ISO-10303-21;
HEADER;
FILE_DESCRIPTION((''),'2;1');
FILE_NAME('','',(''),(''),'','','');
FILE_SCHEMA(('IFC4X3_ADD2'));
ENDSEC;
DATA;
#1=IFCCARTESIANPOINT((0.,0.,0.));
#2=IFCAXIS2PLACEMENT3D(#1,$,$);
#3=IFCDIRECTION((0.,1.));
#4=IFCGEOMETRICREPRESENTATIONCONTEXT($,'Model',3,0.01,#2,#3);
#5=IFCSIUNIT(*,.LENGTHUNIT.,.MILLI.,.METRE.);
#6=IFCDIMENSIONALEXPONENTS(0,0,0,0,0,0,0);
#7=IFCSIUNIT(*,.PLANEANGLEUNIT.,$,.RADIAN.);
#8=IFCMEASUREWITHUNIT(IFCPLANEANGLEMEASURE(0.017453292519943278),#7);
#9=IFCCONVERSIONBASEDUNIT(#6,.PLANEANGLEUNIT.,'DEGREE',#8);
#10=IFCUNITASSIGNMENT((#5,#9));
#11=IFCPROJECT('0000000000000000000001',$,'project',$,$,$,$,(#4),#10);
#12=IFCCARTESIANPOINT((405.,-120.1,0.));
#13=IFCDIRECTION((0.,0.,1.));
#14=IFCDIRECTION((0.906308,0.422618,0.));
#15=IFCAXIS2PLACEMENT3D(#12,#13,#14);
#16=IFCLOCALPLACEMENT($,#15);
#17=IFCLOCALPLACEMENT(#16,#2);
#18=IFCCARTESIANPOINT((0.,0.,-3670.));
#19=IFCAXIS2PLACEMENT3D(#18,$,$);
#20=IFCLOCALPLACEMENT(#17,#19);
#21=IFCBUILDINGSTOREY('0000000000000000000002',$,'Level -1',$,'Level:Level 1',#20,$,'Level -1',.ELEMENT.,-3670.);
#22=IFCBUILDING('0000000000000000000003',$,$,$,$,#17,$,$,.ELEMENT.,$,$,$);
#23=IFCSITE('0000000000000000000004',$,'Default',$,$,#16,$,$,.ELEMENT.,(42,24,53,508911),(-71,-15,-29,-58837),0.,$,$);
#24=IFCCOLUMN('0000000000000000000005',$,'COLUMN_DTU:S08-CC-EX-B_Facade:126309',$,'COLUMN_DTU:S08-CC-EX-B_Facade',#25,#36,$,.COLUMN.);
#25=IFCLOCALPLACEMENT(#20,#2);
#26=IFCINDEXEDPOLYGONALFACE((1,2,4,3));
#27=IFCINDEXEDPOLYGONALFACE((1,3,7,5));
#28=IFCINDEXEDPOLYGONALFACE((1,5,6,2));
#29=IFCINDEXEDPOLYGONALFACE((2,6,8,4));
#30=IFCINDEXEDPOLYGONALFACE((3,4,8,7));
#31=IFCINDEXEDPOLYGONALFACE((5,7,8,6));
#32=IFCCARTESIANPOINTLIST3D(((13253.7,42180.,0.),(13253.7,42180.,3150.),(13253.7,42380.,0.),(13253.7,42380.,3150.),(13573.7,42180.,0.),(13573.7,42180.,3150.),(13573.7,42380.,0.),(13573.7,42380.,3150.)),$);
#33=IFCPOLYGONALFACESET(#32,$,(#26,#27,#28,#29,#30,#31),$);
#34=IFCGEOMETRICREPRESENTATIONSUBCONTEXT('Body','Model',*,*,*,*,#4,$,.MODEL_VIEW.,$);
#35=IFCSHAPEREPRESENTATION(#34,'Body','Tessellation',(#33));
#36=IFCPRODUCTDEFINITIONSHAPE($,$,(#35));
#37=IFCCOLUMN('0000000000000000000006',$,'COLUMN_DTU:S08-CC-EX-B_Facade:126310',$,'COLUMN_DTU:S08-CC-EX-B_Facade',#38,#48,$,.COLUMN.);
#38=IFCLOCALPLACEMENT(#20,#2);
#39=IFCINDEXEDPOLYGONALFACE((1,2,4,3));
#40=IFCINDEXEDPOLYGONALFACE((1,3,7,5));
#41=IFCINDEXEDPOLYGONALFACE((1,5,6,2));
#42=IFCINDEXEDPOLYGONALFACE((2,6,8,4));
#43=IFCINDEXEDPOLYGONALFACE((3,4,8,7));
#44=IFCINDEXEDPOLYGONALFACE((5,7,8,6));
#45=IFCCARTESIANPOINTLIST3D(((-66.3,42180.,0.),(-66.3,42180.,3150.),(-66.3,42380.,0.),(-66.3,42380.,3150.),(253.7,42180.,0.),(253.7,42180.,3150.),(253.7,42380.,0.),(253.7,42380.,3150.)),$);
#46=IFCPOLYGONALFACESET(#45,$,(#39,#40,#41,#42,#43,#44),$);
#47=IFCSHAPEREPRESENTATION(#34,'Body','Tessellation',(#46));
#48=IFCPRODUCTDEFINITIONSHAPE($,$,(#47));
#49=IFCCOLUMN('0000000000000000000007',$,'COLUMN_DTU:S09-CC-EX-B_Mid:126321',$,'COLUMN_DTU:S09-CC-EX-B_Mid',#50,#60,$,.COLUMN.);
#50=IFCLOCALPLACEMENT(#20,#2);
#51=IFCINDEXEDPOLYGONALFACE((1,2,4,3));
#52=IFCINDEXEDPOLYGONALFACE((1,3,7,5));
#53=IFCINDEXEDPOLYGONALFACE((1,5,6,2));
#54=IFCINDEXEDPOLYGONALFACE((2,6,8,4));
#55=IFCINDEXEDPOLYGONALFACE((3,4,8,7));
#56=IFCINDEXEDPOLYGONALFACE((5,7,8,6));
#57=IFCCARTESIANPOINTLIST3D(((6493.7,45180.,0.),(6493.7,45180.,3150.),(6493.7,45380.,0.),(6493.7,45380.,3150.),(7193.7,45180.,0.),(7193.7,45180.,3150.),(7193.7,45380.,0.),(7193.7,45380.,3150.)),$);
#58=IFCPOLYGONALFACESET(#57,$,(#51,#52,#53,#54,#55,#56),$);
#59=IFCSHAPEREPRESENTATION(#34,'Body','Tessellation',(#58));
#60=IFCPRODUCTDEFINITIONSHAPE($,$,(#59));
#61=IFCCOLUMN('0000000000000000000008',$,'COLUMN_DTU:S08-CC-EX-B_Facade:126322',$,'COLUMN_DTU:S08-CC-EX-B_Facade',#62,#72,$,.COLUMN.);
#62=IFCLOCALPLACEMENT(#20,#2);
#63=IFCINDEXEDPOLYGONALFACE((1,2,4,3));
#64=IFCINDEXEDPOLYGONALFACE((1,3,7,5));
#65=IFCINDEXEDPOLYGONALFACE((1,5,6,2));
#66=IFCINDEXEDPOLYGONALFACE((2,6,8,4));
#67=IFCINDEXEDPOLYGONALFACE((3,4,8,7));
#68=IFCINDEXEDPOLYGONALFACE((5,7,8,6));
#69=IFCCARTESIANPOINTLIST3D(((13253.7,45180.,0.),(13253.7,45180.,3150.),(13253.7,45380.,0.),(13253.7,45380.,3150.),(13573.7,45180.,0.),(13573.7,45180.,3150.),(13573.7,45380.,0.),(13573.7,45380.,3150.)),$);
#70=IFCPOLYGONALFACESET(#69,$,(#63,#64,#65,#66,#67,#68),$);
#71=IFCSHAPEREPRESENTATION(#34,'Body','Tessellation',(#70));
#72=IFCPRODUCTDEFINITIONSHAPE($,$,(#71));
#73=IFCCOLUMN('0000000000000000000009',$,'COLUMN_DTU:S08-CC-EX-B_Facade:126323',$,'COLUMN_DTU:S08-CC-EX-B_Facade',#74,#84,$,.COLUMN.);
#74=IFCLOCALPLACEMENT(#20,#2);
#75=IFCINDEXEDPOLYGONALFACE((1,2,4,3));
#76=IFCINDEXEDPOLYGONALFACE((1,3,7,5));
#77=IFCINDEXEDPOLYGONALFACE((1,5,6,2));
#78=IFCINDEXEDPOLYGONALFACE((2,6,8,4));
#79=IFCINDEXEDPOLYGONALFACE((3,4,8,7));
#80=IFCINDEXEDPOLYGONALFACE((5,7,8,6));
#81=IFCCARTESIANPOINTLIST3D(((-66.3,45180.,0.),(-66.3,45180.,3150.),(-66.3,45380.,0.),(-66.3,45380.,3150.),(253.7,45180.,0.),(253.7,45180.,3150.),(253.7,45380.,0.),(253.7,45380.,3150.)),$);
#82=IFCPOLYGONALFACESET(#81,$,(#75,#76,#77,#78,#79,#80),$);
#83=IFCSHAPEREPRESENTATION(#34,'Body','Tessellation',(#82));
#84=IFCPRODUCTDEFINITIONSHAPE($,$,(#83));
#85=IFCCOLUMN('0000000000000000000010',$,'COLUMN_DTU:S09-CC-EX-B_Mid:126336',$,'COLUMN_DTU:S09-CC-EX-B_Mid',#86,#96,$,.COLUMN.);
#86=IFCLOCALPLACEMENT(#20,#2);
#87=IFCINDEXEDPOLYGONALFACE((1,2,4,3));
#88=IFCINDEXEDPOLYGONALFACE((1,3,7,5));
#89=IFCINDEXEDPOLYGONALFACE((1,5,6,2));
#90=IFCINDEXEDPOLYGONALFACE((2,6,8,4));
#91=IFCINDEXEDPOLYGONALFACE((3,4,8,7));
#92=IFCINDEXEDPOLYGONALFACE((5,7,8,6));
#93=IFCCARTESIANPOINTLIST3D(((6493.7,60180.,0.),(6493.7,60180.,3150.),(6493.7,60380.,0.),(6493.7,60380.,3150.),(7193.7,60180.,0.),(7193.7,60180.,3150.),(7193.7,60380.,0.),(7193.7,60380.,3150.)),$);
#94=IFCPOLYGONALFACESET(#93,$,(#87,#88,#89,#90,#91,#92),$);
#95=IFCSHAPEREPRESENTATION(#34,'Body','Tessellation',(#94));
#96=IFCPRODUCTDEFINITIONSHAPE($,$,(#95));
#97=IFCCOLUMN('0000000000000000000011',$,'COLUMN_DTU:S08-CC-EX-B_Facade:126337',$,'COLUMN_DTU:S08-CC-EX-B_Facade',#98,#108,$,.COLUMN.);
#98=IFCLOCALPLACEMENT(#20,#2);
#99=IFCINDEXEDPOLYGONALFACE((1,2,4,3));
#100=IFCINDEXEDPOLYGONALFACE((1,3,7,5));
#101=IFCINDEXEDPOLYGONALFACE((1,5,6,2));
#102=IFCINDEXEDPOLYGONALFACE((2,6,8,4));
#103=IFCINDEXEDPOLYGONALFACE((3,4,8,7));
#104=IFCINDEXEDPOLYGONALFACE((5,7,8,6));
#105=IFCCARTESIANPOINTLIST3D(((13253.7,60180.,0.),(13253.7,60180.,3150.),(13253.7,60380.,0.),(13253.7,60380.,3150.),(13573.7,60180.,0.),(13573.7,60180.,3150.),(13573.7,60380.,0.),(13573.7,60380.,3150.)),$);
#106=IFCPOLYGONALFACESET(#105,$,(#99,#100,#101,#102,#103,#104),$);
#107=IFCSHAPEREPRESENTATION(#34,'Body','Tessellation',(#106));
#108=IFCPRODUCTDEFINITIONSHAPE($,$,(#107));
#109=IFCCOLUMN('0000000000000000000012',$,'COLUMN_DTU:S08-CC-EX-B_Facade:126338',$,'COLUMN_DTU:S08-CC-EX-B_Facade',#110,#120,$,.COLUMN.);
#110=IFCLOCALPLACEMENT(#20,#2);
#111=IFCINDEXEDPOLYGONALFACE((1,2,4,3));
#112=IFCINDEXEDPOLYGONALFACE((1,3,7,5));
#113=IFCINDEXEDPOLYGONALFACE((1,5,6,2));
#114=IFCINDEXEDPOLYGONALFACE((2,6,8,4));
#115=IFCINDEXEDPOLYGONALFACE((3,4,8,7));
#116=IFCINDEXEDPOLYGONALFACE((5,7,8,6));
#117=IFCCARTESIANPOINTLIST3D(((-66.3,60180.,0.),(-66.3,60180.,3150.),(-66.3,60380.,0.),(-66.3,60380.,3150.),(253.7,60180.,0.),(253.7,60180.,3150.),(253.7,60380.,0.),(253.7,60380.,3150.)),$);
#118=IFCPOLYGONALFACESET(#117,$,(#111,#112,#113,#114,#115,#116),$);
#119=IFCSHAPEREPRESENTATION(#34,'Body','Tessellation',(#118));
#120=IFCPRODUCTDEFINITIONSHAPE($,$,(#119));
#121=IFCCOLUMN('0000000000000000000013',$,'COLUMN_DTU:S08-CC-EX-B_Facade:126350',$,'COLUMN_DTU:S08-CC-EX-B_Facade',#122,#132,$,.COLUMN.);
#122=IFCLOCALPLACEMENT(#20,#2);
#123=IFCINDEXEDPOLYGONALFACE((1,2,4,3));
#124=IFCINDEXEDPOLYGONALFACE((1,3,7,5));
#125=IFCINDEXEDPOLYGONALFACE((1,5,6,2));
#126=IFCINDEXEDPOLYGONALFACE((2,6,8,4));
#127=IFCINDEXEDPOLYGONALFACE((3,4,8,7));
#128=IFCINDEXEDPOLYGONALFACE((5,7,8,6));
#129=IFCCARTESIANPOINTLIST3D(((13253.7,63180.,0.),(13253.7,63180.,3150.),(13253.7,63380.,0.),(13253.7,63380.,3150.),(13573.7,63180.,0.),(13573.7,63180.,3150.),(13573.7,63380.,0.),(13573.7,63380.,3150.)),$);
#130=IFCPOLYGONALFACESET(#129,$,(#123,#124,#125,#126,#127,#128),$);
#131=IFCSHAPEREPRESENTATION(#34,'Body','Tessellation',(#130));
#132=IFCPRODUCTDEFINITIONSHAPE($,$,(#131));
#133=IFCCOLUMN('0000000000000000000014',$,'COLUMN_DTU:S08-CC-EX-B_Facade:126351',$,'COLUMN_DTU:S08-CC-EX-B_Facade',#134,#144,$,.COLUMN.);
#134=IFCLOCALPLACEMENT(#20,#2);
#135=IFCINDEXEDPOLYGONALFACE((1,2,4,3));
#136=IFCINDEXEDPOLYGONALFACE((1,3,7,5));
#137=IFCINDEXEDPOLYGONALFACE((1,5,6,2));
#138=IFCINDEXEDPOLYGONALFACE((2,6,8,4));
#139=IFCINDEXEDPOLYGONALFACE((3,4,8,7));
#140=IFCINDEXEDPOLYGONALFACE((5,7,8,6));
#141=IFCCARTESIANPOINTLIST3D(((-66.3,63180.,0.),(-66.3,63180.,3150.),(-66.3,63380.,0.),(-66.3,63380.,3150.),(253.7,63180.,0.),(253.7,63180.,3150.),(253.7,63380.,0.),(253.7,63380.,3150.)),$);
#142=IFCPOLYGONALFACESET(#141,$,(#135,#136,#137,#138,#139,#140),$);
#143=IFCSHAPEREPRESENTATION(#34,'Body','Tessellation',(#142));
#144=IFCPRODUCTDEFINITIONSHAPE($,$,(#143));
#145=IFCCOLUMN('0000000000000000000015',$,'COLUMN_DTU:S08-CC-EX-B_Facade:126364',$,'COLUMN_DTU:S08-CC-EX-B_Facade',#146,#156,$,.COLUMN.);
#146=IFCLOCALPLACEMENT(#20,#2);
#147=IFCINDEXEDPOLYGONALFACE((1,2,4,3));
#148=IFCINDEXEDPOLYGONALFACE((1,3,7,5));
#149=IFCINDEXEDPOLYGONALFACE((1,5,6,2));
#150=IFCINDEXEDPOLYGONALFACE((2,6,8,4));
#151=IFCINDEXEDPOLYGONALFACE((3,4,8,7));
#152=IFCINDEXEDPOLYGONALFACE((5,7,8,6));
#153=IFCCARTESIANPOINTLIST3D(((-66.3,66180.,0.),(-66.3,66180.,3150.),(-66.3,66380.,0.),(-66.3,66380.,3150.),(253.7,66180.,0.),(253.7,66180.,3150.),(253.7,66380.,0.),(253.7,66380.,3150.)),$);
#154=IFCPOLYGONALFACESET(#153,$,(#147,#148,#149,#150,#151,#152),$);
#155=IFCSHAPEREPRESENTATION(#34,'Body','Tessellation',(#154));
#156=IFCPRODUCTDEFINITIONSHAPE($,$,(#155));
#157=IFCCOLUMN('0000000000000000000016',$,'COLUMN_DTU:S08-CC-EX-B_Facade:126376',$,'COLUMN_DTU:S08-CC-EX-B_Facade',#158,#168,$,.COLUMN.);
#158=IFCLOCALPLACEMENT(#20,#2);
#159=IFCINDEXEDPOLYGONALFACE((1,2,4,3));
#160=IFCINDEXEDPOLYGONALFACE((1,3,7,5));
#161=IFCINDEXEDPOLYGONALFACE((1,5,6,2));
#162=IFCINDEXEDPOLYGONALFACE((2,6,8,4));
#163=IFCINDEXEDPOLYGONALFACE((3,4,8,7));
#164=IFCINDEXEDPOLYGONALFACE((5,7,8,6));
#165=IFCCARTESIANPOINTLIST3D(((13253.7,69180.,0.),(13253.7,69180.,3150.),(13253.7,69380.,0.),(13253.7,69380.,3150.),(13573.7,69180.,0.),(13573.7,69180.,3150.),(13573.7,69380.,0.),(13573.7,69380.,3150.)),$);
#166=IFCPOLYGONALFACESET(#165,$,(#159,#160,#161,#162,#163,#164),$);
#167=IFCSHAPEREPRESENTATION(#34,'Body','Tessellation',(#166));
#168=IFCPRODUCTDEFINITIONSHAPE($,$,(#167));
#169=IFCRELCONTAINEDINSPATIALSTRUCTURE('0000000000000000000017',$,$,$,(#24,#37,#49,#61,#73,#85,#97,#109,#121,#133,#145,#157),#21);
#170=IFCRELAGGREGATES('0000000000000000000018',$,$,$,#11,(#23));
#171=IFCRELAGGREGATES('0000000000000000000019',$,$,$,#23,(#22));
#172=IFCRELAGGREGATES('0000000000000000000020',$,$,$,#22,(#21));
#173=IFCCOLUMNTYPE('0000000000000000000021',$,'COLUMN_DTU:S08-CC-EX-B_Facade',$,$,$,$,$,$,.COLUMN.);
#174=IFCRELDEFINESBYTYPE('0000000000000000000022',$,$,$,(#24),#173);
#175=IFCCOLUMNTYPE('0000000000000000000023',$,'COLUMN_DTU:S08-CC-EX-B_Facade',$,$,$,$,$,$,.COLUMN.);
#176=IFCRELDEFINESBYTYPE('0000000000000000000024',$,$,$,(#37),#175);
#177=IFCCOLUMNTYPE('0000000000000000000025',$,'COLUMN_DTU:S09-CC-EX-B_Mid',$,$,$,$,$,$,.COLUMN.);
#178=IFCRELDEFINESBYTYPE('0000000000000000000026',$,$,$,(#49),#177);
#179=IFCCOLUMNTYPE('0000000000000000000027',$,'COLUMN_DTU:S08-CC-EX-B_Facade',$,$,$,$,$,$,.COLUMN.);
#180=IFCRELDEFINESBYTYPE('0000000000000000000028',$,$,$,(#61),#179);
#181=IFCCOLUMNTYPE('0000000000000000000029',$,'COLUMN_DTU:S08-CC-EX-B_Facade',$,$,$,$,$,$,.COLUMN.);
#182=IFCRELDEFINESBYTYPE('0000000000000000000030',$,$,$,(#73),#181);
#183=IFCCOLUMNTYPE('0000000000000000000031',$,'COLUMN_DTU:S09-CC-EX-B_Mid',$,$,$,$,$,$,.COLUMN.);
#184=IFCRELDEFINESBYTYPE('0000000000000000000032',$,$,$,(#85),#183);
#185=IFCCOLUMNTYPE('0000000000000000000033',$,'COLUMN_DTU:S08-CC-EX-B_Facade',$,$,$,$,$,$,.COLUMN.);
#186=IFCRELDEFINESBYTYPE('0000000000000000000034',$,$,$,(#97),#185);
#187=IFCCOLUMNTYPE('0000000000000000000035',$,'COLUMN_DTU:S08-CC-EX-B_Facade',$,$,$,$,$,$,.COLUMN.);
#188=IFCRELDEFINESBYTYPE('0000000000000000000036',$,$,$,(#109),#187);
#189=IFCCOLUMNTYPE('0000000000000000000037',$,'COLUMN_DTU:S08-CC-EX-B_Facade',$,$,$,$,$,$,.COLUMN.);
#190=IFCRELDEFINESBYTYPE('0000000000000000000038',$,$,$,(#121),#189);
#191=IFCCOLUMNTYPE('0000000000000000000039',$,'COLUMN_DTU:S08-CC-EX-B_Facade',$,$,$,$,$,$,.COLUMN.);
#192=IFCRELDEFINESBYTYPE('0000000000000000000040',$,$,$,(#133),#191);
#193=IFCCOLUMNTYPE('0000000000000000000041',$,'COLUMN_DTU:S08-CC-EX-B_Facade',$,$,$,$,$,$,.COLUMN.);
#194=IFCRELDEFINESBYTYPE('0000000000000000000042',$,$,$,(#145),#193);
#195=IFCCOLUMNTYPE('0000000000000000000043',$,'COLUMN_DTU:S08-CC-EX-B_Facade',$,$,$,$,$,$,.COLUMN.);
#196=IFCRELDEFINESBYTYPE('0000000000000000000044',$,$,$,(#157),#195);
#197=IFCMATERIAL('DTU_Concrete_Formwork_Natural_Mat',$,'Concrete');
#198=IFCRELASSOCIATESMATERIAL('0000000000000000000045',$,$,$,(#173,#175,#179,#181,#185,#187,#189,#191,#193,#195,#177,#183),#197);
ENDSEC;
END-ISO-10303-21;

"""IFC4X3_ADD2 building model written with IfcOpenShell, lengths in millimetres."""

from ifc_helpers import new_model, entity, si_unit, converted_unit, direction, frame, frame_2d, origin, origin_2d_with_axis, place, context, subcontext, project, spatial, rectangle, extrude, source, transform, mapped, material, material_profile, profile_set, type_object, type_shapes, element, save


model = new_model("IFC4X3_ADD2")

# Units and contexts
model_context = context("Model", 3, precision=0.01, world=origin(), true_north=direction((0.0, 1.0)))
body_context = subcontext(model_context, "Body", "Model", "MODEL_VIEW")
ifc_project = project(units=[si_unit("LENGTHUNIT", "METRE", prefix="MILLI"), converted_unit("PLANEANGLEUNIT", "DEGREE", entity("IfcPlaneAngleMeasure", 0.017453292519943278), si_unit("PLANEANGLEUNIT", "RADIAN"), dimensions=[0, 0, 0, 0, 0, 0, 0])], contexts=[model_context])

# Site, building, storey
site_placement = place(None, frame((405.0, -120.1, 0.0), z_axis=(0.0, 0.0, 1.0), x_axis=(0.906308, 0.422618, 0.0)))
site = spatial("IfcSite", under=ifc_project, at=site_placement, Name="Default", CompositionType="ELEMENT", RefLatitude=(42, 24, 53, 508911), RefLongitude=(-71, -15, -29, -58837), RefElevation=0.0)
building_placement = place(site_placement, origin())
building = spatial("IfcBuilding", under=site, at=building_placement, CompositionType="ELEMENT")
storey_placement = place(building_placement, frame((0.0, 0.0, -3670.0)))
storey = spatial("IfcBuildingStorey", under=building, at=storey_placement, Name="Level -1", ObjectType="Level:Level 1", LongName="Level -1", CompositionType="ELEMENT", Elevation=-3670.0)

# Columns
ifc_material = material(Name="DTU_Concrete_Formwork_Natural_Mat", Category="Concrete")
ifc_material_profile_1 = material_profile(ifc_material, rectangle(XDim=200.0, YDim=320.0, at=origin_2d_with_axis()), Name="S08-CC-EX-B_Facade")
ifc_profile_set_1 = profile_set([ifc_material_profile_1], Name="S08-CC-EX-B_Facade")
ifc_material_profile_2 = material_profile(ifc_material, rectangle(XDim=200.0, YDim=700.0, at=frame_2d((0.0, 0.0), x_axis=(1.0, 0.0))), Name="S09-CC-EX-B_Mid")
ifc_profile_set_2 = profile_set([ifc_material_profile_2], Name="S09-CC-EX-B_Mid")
column_type_1 = type_object("IfcColumnType", Name="COLUMN_DTU:S08-CC-EX-B_Facade", PredefinedType="COLUMN", material=ifc_profile_set_1)
shared_shape_1 = source(origin(), body_context, "Body", "SweptSolid", [
    extrude(rectangle(XDim=200.0, YDim=320.0, at=frame_2d((0.0, 0.0), x_axis=(1.0, 0.0))), frame((13413.7, 42280.0, -3670.0), z_axis=(0.0, 0.0, 1.0), x_axis=(0.0, 1.0, 0.0)), (0.0, 0.0, 1.0), 3150.0),
])
type_shapes(column_type_1, [shared_shape_1])
column_1_placement = place(storey_placement, frame((0.0, 0.0, 3670.0)))
element("IfcColumn", 1, at=column_1_placement, inside=storey, type_object=column_type_1, Name="COLUMN_DTU:S08-CC-EX-B_Facade:126309", ObjectType="COLUMN_DTU:S08-CC-EX-B_Facade", PredefinedType="COLUMN", context=body_context, shape_type="MappedRepresentation", body=[
    mapped(shared_shape_1, transform((0.0, 0.0, 0.0), scale=1.0)),
])
column_type_2 = type_object("IfcColumnType", Name="COLUMN_DTU:S08-CC-EX-B_Facade", PredefinedType="COLUMN", material=ifc_profile_set_1)
shared_shape_2 = source(origin(), body_context, "Body", "SweptSolid", [
    extrude(rectangle(XDim=200.0, YDim=320.0, at=frame_2d((0.0, 0.0), x_axis=(1.0, 0.0))), frame((93.7, 42280.0, -3670.0), z_axis=(0.0, 0.0, 1.0), x_axis=(0.0, 1.0, 0.0)), (0.0, 0.0, 1.0), 3150.0),
])
type_shapes(column_type_2, [shared_shape_2])
column_2_placement = place(storey_placement, frame((0.0, 0.0, 3670.0)))
element("IfcColumn", 2, at=column_2_placement, inside=storey, type_object=column_type_2, Name="COLUMN_DTU:S08-CC-EX-B_Facade:126310", ObjectType="COLUMN_DTU:S08-CC-EX-B_Facade", PredefinedType="COLUMN", context=body_context, shape_type="MappedRepresentation", body=[
    mapped(shared_shape_2, transform((0.0, 0.0, 0.0), scale=1.0)),
])
column_type_3 = type_object("IfcColumnType", Name="COLUMN_DTU:S09-CC-EX-B_Mid", PredefinedType="COLUMN", material=ifc_profile_set_2)
shared_shape_3 = source(origin(), body_context, "Body", "SweptSolid", [
    extrude(rectangle(XDim=200.0, YDim=700.0, at=frame_2d((0.0, 0.0), x_axis=(1.0, 0.0))), frame((6843.7, 45280.0, -3670.0), z_axis=(0.0, 0.0, 1.0), x_axis=(0.0, 1.0, 0.0)), (0.0, 0.0, 1.0), 3150.0),
])
type_shapes(column_type_3, [shared_shape_3])
column_3_placement = place(storey_placement, frame((0.0, 0.0, 3670.0)))
element("IfcColumn", 3, at=column_3_placement, inside=storey, type_object=column_type_3, Name="COLUMN_DTU:S09-CC-EX-B_Mid:126321", ObjectType="COLUMN_DTU:S09-CC-EX-B_Mid", PredefinedType="COLUMN", context=body_context, shape_type="MappedRepresentation", body=[
    mapped(shared_shape_3, transform((0.0, 0.0, 0.0), scale=1.0)),
])
column_type_4 = type_object("IfcColumnType", Name="COLUMN_DTU:S08-CC-EX-B_Facade", PredefinedType="COLUMN", material=ifc_profile_set_1)
shared_shape_4 = source(origin(), body_context, "Body", "SweptSolid", [
    extrude(rectangle(XDim=200.0, YDim=320.0, at=frame_2d((0.0, 0.0), x_axis=(1.0, 0.0))), frame((13413.7, 45280.0, -3670.0), z_axis=(0.0, 0.0, 1.0), x_axis=(0.0, 1.0, 0.0)), (0.0, 0.0, 1.0), 3150.0),
])
type_shapes(column_type_4, [shared_shape_4])
column_4_placement = place(storey_placement, frame((0.0, 0.0, 3670.0)))
element("IfcColumn", 4, at=column_4_placement, inside=storey, type_object=column_type_4, Name="COLUMN_DTU:S08-CC-EX-B_Facade:126322", ObjectType="COLUMN_DTU:S08-CC-EX-B_Facade", PredefinedType="COLUMN", context=body_context, shape_type="MappedRepresentation", body=[
    mapped(shared_shape_4, transform((0.0, 0.0, 0.0), scale=1.0)),
])
column_type_5 = type_object("IfcColumnType", Name="COLUMN_DTU:S08-CC-EX-B_Facade", PredefinedType="COLUMN", material=ifc_profile_set_1)
shared_shape_5 = source(origin(), body_context, "Body", "SweptSolid", [
    extrude(rectangle(XDim=200.0, YDim=320.0, at=frame_2d((0.0, 0.0), x_axis=(1.0, 0.0))), frame((93.7, 45280.0, -3670.0), z_axis=(0.0, 0.0, 1.0), x_axis=(0.0, 1.0, 0.0)), (0.0, 0.0, 1.0), 3150.0),
])
type_shapes(column_type_5, [shared_shape_5])
column_5_placement = place(storey_placement, frame((0.0, 0.0, 3670.0)))
element("IfcColumn", 5, at=column_5_placement, inside=storey, type_object=column_type_5, Name="COLUMN_DTU:S08-CC-EX-B_Facade:126323", ObjectType="COLUMN_DTU:S08-CC-EX-B_Facade", PredefinedType="COLUMN", context=body_context, shape_type="MappedRepresentation", body=[
    mapped(shared_shape_5, transform((0.0, 0.0, 0.0), scale=1.0)),
])
column_type_6 = type_object("IfcColumnType", Name="COLUMN_DTU:S09-CC-EX-B_Mid", PredefinedType="COLUMN", material=ifc_profile_set_2)
shared_shape_6 = source(origin(), body_context, "Body", "SweptSolid", [
    extrude(rectangle(XDim=200.0, YDim=700.0, at=frame_2d((0.0, 0.0), x_axis=(1.0, 0.0))), frame((6843.7, 60280.0, -3670.0), z_axis=(0.0, 0.0, 1.0), x_axis=(0.0, -1.0, 0.0)), (0.0, 0.0, 1.0), 3150.0),
])
type_shapes(column_type_6, [shared_shape_6])
column_6_placement = place(storey_placement, frame((0.0, 0.0, 3670.0)))
element("IfcColumn", 6, at=column_6_placement, inside=storey, type_object=column_type_6, Name="COLUMN_DTU:S09-CC-EX-B_Mid:126336", ObjectType="COLUMN_DTU:S09-CC-EX-B_Mid", PredefinedType="COLUMN", context=body_context, shape_type="MappedRepresentation", body=[
    mapped(shared_shape_6, transform((0.0, 0.0, 0.0), scale=1.0)),
])
column_type_7 = type_object("IfcColumnType", Name="COLUMN_DTU:S08-CC-EX-B_Facade", PredefinedType="COLUMN", material=ifc_profile_set_1)
shared_shape_7 = source(origin(), body_context, "Body", "SweptSolid", [
    extrude(rectangle(XDim=200.0, YDim=320.0, at=frame_2d((0.0, 0.0), x_axis=(1.0, 0.0))), frame((13413.7, 60280.0, -3670.0), z_axis=(0.0, 0.0, 1.0), x_axis=(0.0, 1.0, 0.0)), (0.0, 0.0, 1.0), 3150.0),
])
type_shapes(column_type_7, [shared_shape_7])
column_7_placement = place(storey_placement, frame((0.0, 0.0, 3670.0)))
element("IfcColumn", 7, at=column_7_placement, inside=storey, type_object=column_type_7, Name="COLUMN_DTU:S08-CC-EX-B_Facade:126337", ObjectType="COLUMN_DTU:S08-CC-EX-B_Facade", PredefinedType="COLUMN", context=body_context, shape_type="MappedRepresentation", body=[
    mapped(shared_shape_7, transform((0.0, 0.0, 0.0), scale=1.0)),
])
column_type_8 = type_object("IfcColumnType", Name="COLUMN_DTU:S08-CC-EX-B_Facade", PredefinedType="COLUMN", material=ifc_profile_set_1)
shared_shape_8 = source(origin(), body_context, "Body", "SweptSolid", [
    extrude(rectangle(XDim=200.0, YDim=320.0, at=frame_2d((0.0, 0.0), x_axis=(1.0, 0.0))), frame((93.7, 60280.0, -3670.0), z_axis=(0.0, 0.0, 1.0), x_axis=(0.0, -1.0, 0.0)), (0.0, 0.0, 1.0), 3150.0),
])
type_shapes(column_type_8, [shared_shape_8])
column_8_placement = place(storey_placement, frame((0.0, 0.0, 3670.0)))
element("IfcColumn", 8, at=column_8_placement, inside=storey, type_object=column_type_8, Name="COLUMN_DTU:S08-CC-EX-B_Facade:126338", ObjectType="COLUMN_DTU:S08-CC-EX-B_Facade", PredefinedType="COLUMN", context=body_context, shape_type="MappedRepresentation", body=[
    mapped(shared_shape_8, transform((0.0, 0.0, 0.0), scale=1.0)),
])
column_type_9 = type_object("IfcColumnType", Name="COLUMN_DTU:S08-CC-EX-B_Facade", PredefinedType="COLUMN", material=ifc_profile_set_1)
shared_shape_9 = source(origin(), body_context, "Body", "SweptSolid", [
    extrude(rectangle(XDim=200.0, YDim=320.0, at=frame_2d((0.0, 0.0), x_axis=(1.0, 0.0))), frame((13413.7, 63280.0, -3670.0), z_axis=(0.0, 0.0, 1.0), x_axis=(0.0, 1.0, 0.0)), (0.0, 0.0, 1.0), 3150.0),
])
type_shapes(column_type_9, [shared_shape_9])
column_9_placement = place(storey_placement, frame((0.0, 0.0, 3670.0)))
element("IfcColumn", 9, at=column_9_placement, inside=storey, type_object=column_type_9, Name="COLUMN_DTU:S08-CC-EX-B_Facade:126350", ObjectType="COLUMN_DTU:S08-CC-EX-B_Facade", PredefinedType="COLUMN", context=body_context, shape_type="MappedRepresentation", body=[
    mapped(shared_shape_9, transform((0.0, 0.0, 0.0), scale=1.0)),
])
column_type_10 = type_object("IfcColumnType", Name="COLUMN_DTU:S08-CC-EX-B_Facade", PredefinedType="COLUMN", material=ifc_profile_set_1)
shared_shape_10 = source(origin(), body_context, "Body", "SweptSolid", [
    extrude(rectangle(XDim=200.0, YDim=320.0, at=origin_2d_with_axis()), frame((93.7, 63280.0, -3670.0), z_axis=(0.0, 0.0, 1.0), x_axis=(0.0, -1.0, 0.0)), (0.0, 0.0, 1.0), 3150.0),
])
type_shapes(column_type_10, [shared_shape_10])
column_10_placement = place(storey_placement, frame((0.0, 0.0, 3670.0)))
element("IfcColumn", 10, at=column_10_placement, inside=storey, type_object=column_type_10, Name="COLUMN_DTU:S08-CC-EX-B_Facade:126351", ObjectType="COLUMN_DTU:S08-CC-EX-B_Facade", PredefinedType="COLUMN", context=body_context, shape_type="MappedRepresentation", body=[
    mapped(shared_shape_10, transform((0.0, 0.0, 0.0), scale=1.0)),
])
column_type_11 = type_object("IfcColumnType", Name="COLUMN_DTU:S08-CC-EX-B_Facade", PredefinedType="COLUMN", material=ifc_profile_set_1)
shared_shape_11 = source(origin(), body_context, "Body", "SweptSolid", [
    extrude(rectangle(XDim=200.0, YDim=320.0, at=origin_2d_with_axis()), frame((93.7, 66280.0, -3670.0), z_axis=(0.0, 0.0, 1.0), x_axis=(0.0, -1.0, 0.0)), (0.0, 0.0, 1.0), 3150.0),
])
type_shapes(column_type_11, [shared_shape_11])
column_11_placement = place(storey_placement, frame((0.0, 0.0, 3670.0)))
element("IfcColumn", 11, at=column_11_placement, inside=storey, type_object=column_type_11, Name="COLUMN_DTU:S08-CC-EX-B_Facade:126364", ObjectType="COLUMN_DTU:S08-CC-EX-B_Facade", PredefinedType="COLUMN", context=body_context, shape_type="MappedRepresentation", body=[
    mapped(shared_shape_11, transform((0.0, 0.0, 0.0), scale=1.0)),
])
column_type_12 = type_object("IfcColumnType", Name="COLUMN_DTU:S08-CC-EX-B_Facade", PredefinedType="COLUMN", material=ifc_profile_set_1)
shared_shape_12 = source(origin(), body_context, "Body", "SweptSolid", [
    extrude(rectangle(XDim=200.0, YDim=320.0, at=frame_2d((0.0, 0.0), x_axis=(1.0, 0.0))), frame((13413.7, 69280.0, -3670.0), z_axis=(0.0, 0.0, 1.0), x_axis=(0.0, 1.0, 0.0)), (0.0, 0.0, 1.0), 3150.0),
])
type_shapes(column_type_12, [shared_shape_12])
column_12_placement = place(storey_placement, frame((0.0, 0.0, 3670.0)))
element("IfcColumn", 12, at=column_12_placement, inside=storey, type_object=column_type_12, Name="COLUMN_DTU:S08-CC-EX-B_Facade:126376", ObjectType="COLUMN_DTU:S08-CC-EX-B_Facade", PredefinedType="COLUMN", context=body_context, shape_type="MappedRepresentation", body=[
    mapped(shared_shape_12, transform((0.0, 0.0, 0.0), scale=1.0)),
])

save(model, "model.ifc")
